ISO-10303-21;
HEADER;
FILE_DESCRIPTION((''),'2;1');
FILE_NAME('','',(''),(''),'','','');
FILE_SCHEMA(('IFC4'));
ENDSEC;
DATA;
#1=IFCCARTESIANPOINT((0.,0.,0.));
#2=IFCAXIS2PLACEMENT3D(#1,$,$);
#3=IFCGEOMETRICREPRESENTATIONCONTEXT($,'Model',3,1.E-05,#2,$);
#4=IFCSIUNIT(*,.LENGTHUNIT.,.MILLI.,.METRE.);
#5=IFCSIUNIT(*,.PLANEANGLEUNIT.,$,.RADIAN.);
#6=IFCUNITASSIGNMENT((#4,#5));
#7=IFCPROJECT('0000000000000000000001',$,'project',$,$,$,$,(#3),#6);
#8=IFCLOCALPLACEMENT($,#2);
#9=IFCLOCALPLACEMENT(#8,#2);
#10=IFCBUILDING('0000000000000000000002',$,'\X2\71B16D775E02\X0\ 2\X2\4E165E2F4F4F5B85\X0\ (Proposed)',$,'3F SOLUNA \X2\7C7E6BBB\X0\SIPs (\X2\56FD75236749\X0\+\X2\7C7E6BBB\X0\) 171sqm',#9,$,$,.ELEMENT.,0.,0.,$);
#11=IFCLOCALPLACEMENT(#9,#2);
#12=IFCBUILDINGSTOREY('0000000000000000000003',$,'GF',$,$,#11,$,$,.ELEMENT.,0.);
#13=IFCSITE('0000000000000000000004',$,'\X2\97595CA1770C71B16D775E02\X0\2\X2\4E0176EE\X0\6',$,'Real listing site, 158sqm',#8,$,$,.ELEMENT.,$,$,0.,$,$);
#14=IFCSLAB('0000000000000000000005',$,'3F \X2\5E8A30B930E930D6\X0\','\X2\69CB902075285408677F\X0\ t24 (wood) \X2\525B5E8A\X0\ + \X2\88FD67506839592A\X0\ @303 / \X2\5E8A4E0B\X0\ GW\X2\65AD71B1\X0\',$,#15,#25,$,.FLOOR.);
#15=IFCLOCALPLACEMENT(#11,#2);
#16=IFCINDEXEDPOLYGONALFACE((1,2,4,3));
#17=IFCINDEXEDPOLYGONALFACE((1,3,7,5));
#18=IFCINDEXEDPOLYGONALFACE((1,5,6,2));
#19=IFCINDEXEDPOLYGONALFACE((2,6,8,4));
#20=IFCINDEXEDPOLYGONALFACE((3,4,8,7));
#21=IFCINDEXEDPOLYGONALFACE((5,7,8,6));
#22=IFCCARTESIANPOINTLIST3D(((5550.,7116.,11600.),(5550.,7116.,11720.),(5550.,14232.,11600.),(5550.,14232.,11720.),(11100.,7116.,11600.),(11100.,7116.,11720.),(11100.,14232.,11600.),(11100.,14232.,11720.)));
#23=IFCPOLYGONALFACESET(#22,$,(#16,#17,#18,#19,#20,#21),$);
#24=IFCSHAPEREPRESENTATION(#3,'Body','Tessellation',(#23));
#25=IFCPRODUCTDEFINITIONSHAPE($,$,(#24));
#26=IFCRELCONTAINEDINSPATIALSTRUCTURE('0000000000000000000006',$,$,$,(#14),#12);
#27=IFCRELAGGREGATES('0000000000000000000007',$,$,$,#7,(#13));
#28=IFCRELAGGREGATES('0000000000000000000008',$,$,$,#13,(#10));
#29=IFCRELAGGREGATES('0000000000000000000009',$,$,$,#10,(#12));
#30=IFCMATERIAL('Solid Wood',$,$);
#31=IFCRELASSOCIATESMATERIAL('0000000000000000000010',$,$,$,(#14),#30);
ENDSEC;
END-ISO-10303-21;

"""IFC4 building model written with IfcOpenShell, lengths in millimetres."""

from ifc_helpers import new_model, si_unit, frame, frame_2d, origin, place, context, project, spatial, rectangle, extrude, material, element, save


model = new_model("IFC4")

# Units and contexts
model_context = context("Model", 3, precision=1e-05, world=origin())
ifc_project = project(units=[si_unit("LENGTHUNIT", "METRE", prefix="MILLI"), si_unit("PLANEANGLEUNIT", "RADIAN")], contexts=[model_context])

# Site, building, storey
site_placement = place(None, origin())
site = spatial("IfcSite", under=ifc_project, at=site_placement, Name="静岡県熱海市2丁目6", ObjectType="Real listing site, 158sqm", CompositionType="ELEMENT", RefElevation=0.0)
building_placement = place(site_placement, origin())
building = spatial("IfcBuilding", under=site, at=building_placement, Name="熱海市 2世帯住宅 (Proposed)", ObjectType="3F SOLUNA 籾殻SIPs (国産杉+籾殻) 171sqm", CompositionType="ELEMENT", ElevationOfRefHeight=0.0, ElevationOfTerrain=0.0)
storey_placement = place(building_placement, origin())
storey = spatial("IfcBuildingStorey", under=building, at=storey_placement, Name="GF", CompositionType="ELEMENT", Elevation=0.0)

# Slab
ifc_material_1 = material(Name="Solid Wood")
slab_placement = place(storey_placement, frame((2775.0, 3558.0, 5800.0)))
element("IfcSlab", 1, at=slab_placement, inside=storey, material=ifc_material_1, Name="3F 床スラブ", Description="構造用合板 t24 (wood) 剛床 + 製材根太 @303 / 床下 GW断熱", PredefinedType="FLOOR", context=model_context, shape_type="SweptSolid", body=[
    extrude(rectangle(XDim=5550.0, YDim=7116.0, at=frame_2d((2775.0, 3558.0))), frame((2775.0, 3558.0, 5800.0)), (0.0, 0.0, 1.0), 120.0),
])

save(model, "model.ifc")
